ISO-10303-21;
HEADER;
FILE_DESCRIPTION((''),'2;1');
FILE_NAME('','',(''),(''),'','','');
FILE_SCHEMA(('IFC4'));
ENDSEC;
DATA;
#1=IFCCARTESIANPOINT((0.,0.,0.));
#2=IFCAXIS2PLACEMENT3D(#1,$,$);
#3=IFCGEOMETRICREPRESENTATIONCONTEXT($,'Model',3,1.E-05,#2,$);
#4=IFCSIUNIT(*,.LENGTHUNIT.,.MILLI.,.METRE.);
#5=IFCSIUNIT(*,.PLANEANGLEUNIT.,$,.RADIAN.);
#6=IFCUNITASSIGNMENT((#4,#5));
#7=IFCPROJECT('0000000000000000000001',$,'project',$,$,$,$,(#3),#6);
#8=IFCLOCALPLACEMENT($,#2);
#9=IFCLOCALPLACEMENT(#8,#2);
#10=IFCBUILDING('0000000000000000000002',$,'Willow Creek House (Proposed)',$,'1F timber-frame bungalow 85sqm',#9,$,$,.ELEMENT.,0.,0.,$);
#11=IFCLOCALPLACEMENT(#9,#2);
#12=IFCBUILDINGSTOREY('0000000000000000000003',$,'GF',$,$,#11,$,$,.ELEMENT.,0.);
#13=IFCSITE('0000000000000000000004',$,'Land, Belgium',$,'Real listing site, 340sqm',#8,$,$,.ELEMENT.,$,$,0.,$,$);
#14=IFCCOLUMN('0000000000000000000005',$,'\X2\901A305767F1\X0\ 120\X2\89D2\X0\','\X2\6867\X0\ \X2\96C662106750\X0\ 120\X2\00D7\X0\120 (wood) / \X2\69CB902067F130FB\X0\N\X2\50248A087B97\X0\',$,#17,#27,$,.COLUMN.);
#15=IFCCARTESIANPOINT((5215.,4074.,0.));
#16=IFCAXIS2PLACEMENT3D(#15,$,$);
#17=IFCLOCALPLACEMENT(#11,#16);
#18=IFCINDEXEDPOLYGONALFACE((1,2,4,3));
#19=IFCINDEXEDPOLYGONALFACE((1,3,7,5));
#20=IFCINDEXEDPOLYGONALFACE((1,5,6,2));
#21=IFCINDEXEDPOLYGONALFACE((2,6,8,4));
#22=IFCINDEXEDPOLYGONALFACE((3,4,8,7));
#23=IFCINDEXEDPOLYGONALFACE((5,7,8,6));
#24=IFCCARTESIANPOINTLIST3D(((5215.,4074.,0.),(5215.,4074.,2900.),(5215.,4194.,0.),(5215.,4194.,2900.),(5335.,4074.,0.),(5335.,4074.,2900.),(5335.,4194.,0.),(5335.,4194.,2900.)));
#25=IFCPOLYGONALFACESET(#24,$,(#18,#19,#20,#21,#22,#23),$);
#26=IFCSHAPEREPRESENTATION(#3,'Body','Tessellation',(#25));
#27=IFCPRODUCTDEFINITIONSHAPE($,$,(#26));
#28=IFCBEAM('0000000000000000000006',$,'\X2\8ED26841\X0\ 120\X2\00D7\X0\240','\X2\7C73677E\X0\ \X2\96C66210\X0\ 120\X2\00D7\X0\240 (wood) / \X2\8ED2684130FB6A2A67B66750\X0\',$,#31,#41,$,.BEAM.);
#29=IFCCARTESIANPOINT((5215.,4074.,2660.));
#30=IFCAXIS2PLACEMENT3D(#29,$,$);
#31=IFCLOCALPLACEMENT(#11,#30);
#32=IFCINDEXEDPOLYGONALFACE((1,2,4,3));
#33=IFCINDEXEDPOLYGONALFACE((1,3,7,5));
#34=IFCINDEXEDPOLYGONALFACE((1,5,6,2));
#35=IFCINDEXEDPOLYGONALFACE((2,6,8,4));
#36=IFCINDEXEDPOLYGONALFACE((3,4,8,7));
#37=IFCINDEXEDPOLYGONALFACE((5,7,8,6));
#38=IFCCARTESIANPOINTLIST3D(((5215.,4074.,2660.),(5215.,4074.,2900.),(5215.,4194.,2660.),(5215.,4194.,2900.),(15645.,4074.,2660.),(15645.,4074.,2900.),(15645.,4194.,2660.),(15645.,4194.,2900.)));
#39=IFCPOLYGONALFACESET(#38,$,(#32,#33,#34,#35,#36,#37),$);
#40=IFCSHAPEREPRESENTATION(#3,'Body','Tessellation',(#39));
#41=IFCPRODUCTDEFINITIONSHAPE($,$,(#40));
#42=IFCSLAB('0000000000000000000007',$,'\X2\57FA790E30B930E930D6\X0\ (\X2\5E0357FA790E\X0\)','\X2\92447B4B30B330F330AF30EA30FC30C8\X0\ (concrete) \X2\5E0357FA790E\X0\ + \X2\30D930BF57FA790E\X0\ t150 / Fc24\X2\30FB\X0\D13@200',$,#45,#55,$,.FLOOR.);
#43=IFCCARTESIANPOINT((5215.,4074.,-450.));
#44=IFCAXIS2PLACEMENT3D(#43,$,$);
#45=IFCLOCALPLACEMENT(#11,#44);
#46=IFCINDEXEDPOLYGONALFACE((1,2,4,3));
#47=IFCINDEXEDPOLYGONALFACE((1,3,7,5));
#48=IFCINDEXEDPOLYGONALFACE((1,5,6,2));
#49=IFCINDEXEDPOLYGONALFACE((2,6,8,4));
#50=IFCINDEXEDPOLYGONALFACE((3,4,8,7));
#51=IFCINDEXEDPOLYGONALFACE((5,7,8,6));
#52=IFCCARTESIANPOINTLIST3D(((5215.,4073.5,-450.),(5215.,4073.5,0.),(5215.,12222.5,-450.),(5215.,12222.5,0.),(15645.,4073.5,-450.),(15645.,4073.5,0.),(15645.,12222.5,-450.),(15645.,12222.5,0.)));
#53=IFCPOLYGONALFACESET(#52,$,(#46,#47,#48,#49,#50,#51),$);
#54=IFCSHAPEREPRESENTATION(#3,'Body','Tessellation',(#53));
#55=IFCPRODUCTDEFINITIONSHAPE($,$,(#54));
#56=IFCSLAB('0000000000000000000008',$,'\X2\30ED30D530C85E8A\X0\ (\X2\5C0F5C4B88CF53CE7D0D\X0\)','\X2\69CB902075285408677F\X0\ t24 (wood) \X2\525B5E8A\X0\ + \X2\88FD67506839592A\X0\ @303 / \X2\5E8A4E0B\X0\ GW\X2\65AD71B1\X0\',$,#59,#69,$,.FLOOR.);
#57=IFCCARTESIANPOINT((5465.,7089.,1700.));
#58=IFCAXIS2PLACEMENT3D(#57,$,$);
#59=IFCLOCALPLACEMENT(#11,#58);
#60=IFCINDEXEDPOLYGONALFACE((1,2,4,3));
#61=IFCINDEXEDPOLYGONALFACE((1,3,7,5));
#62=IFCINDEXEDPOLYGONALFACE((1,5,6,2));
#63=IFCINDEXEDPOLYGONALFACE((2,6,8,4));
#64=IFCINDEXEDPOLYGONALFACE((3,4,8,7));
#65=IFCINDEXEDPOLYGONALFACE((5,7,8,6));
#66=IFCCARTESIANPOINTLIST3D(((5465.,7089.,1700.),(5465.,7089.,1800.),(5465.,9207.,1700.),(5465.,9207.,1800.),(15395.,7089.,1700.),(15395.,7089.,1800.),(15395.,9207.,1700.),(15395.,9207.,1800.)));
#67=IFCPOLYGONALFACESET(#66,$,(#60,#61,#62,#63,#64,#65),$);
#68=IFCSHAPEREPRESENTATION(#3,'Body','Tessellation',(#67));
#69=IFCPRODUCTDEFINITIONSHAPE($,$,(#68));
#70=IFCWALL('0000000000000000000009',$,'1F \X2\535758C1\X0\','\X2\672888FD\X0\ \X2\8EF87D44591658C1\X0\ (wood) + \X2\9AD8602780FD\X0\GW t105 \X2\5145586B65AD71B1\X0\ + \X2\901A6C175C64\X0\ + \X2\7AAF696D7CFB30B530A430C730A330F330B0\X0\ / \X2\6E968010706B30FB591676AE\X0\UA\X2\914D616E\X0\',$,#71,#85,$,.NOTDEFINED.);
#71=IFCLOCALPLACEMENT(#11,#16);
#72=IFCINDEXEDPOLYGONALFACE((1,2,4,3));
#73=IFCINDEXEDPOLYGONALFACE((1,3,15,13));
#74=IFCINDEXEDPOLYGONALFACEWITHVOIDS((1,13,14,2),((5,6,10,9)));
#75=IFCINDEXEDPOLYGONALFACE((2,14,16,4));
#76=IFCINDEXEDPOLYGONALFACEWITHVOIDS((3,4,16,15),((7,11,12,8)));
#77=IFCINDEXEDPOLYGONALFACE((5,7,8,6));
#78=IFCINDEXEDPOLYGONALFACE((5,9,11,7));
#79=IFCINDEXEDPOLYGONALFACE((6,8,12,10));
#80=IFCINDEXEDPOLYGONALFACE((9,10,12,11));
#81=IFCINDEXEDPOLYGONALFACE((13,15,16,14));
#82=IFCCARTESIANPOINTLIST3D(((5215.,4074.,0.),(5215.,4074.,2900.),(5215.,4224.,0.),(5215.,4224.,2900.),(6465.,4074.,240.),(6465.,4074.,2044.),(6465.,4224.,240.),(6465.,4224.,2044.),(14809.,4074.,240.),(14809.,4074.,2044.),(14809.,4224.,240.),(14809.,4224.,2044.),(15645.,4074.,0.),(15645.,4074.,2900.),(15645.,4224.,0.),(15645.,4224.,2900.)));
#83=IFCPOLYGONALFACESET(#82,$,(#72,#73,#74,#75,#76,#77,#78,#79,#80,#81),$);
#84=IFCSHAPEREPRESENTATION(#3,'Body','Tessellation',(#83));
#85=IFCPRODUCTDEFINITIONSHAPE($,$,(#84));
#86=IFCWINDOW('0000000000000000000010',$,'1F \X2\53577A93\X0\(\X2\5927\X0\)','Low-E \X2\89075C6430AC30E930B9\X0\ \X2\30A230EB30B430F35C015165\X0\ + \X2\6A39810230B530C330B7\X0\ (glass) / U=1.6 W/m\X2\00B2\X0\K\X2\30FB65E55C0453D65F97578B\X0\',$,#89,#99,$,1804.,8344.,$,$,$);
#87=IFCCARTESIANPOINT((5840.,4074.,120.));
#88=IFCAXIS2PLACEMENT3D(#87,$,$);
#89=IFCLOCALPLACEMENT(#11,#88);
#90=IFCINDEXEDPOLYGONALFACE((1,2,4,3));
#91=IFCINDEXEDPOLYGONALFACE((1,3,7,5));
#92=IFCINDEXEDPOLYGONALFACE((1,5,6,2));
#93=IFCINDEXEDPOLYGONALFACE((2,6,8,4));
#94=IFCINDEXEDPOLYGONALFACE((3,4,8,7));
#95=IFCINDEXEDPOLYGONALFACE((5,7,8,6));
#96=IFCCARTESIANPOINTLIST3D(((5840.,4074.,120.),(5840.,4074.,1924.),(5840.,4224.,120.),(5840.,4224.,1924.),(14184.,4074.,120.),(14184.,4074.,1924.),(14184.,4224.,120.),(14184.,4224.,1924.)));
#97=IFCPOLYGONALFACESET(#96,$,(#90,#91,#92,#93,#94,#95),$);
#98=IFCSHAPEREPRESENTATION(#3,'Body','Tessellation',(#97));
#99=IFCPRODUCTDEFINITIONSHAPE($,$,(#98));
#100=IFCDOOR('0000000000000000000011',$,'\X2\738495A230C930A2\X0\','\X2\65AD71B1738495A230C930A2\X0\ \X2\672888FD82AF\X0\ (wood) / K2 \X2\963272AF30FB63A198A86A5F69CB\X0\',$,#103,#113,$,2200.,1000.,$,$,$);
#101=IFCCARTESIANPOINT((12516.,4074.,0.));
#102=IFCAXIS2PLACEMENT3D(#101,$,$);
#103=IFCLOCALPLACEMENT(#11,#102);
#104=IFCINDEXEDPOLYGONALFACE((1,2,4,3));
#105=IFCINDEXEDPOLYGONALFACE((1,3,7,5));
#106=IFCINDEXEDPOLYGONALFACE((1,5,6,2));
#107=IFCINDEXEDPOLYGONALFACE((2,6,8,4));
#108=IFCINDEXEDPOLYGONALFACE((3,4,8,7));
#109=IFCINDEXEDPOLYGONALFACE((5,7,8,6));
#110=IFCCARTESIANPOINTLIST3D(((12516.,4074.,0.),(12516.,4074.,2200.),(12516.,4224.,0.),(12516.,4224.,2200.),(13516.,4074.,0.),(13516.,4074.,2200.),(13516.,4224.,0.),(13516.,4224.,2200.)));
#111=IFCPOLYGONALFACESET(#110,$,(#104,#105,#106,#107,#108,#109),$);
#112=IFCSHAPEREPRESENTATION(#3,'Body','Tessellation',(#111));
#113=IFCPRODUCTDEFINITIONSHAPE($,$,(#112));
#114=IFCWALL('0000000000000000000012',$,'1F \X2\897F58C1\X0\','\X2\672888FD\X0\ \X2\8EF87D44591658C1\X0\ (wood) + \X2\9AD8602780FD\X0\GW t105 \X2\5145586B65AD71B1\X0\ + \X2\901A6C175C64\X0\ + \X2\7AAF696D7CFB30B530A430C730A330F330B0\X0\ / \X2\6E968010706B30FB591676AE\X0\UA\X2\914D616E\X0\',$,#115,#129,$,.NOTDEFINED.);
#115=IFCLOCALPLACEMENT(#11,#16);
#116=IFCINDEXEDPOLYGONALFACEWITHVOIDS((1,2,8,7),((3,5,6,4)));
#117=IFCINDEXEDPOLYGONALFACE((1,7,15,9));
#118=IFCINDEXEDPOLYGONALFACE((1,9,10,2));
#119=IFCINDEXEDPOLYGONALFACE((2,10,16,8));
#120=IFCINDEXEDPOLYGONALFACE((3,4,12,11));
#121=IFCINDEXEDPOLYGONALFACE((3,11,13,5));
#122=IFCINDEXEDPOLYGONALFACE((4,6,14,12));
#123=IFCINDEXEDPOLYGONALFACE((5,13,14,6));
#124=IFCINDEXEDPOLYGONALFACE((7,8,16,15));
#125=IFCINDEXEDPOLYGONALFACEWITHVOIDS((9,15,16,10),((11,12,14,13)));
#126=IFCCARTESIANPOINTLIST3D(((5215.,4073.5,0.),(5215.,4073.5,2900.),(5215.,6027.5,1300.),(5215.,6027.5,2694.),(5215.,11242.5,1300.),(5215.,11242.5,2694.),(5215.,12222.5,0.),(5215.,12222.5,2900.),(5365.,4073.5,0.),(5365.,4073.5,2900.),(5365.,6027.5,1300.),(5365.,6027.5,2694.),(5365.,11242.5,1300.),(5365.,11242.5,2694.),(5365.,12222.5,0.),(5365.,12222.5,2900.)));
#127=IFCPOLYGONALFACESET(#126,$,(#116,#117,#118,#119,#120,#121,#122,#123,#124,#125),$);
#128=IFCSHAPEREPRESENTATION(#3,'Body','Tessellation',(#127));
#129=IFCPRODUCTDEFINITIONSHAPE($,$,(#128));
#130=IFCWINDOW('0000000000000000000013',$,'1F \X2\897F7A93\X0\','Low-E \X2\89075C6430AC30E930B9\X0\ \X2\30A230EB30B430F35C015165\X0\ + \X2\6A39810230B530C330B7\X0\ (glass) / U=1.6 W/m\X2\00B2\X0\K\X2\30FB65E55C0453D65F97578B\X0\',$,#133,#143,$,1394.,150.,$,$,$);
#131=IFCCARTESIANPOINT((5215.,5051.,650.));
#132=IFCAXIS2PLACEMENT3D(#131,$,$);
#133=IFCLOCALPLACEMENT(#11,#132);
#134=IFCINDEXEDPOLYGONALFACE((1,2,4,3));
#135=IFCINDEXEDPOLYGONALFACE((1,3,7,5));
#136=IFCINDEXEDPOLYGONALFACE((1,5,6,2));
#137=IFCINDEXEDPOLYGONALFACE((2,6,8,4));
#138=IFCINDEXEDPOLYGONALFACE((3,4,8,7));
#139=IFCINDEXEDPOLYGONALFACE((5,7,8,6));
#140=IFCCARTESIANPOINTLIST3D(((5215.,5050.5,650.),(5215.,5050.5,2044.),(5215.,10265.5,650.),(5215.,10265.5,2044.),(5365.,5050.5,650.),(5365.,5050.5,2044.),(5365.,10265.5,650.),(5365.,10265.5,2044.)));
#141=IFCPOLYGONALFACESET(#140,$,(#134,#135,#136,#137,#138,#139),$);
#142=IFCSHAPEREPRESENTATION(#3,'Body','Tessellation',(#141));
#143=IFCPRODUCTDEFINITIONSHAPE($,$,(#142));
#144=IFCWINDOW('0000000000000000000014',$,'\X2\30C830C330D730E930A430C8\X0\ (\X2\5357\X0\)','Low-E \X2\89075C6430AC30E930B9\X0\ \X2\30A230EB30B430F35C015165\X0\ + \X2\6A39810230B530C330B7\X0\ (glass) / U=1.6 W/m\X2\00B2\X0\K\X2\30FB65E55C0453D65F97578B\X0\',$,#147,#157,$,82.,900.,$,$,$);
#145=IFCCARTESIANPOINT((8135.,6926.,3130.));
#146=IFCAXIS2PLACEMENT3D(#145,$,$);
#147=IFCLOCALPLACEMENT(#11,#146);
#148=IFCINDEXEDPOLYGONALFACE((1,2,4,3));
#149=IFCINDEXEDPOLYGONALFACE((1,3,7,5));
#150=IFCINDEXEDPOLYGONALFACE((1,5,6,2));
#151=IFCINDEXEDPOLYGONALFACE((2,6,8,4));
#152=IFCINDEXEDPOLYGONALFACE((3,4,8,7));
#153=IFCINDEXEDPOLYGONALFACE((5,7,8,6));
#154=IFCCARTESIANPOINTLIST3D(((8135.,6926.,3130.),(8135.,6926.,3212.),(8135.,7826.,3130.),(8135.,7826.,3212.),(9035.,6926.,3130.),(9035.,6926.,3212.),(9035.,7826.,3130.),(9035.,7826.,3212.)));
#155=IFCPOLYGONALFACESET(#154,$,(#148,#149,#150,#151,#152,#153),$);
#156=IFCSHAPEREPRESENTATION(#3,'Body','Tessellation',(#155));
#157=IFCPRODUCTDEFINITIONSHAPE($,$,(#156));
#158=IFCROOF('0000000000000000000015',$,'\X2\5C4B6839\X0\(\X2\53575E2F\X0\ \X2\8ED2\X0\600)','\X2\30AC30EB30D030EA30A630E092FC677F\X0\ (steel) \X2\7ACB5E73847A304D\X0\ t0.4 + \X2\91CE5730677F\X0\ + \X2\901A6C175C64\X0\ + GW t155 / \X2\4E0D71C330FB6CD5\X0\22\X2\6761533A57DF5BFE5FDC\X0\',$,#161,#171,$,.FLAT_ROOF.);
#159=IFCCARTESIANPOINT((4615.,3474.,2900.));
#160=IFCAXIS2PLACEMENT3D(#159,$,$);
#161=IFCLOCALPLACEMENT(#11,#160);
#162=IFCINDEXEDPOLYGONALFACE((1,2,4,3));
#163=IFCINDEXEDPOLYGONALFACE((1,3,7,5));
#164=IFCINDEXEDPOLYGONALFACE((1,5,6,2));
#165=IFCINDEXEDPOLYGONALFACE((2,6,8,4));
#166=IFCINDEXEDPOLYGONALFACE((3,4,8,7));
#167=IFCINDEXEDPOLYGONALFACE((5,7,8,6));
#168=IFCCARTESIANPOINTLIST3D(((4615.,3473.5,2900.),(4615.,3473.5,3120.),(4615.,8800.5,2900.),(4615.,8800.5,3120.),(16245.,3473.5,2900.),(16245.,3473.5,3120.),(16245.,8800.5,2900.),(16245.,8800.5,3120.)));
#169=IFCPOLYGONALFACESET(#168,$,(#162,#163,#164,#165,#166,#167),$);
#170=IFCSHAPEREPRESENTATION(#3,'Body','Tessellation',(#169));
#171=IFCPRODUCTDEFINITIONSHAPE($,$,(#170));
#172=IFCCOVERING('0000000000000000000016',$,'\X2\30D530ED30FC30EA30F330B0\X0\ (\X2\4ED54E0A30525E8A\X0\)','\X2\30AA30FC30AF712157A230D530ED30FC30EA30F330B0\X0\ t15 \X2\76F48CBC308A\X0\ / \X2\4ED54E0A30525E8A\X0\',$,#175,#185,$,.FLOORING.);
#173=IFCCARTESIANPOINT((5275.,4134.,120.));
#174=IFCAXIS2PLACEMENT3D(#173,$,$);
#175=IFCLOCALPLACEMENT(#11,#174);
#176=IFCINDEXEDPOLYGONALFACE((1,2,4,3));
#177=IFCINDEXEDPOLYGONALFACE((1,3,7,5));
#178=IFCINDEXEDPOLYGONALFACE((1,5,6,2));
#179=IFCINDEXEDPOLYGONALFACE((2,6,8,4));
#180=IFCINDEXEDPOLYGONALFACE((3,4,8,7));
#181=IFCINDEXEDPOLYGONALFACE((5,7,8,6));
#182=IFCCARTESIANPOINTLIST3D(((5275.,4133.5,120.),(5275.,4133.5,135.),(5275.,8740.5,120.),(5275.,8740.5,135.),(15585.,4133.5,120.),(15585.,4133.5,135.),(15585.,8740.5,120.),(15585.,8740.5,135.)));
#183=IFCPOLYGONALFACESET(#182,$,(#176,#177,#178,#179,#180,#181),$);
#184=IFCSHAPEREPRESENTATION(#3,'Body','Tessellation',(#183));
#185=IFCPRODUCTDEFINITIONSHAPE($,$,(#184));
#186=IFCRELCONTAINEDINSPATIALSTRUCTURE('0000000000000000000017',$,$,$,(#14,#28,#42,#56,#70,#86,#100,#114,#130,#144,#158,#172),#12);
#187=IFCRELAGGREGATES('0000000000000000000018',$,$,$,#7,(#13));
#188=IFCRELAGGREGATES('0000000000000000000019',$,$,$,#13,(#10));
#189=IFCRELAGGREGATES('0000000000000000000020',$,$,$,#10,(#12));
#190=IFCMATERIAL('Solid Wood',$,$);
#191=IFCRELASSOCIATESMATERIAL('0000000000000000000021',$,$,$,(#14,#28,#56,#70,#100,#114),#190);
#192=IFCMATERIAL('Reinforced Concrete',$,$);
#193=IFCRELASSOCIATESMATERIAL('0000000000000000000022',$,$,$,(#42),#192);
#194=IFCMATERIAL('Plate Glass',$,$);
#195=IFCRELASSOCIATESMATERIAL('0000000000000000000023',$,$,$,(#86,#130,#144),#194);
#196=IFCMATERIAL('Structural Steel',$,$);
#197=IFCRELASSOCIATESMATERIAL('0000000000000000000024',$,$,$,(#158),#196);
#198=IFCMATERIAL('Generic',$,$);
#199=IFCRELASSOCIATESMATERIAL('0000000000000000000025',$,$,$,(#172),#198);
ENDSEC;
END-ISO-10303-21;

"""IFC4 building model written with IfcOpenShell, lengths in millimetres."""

from ifc_helpers import new_model, si_unit, frame, frame_2d, origin, place, context, project, spatial, rectangle, extrude, material, element, fill, save


model = new_model("IFC4")

# Units and contexts
model_context = context("Model", 3, precision=1e-05, world=origin())
ifc_project = project(units=[si_unit("LENGTHUNIT", "METRE", prefix="MILLI"), si_unit("PLANEANGLEUNIT", "RADIAN")], contexts=[model_context])

# Site, building, storey
site_placement = place(None, origin())
site = spatial("IfcSite", under=ifc_project, at=site_placement, Name="Land, Belgium", ObjectType="Real listing site, 340sqm", CompositionType="ELEMENT", RefElevation=0.0)
building_placement = place(site_placement, origin())
building = spatial("IfcBuilding", under=site, at=building_placement, Name="Willow Creek House (Proposed)", ObjectType="1F timber-frame bungalow 85sqm", CompositionType="ELEMENT", ElevationOfRefHeight=0.0, ElevationOfTerrain=0.0)
storey_placement = place(building_placement, origin())
storey = spatial("IfcBuildingStorey", under=building, at=storey_placement, Name="GF", CompositionType="ELEMENT", Elevation=0.0)

# Column
ifc_material_1 = material(Name="Solid Wood")
column_1_placement = place(storey_placement, frame((5215.0, 4074.0, 0.0)))
element("IfcColumn", 1, at=column_1_placement, inside=storey, material=ifc_material_1, Name="通し柱 120角", Description="桧 集成材 120×120 (wood) / 構造柱・N値計算", PredefinedType="COLUMN", context=model_context, shape_type="SweptSolid", body=[
    extrude(rectangle(XDim=120.0, YDim=120.0, at=frame_2d((60.0, 60.0))), frame((5215.0, 4074.0, 0.0)), (0.0, 0.0, 1.0), 2900.0),
])

# Beam
beam_1_placement = place(storey_placement, frame((5215.0, 4074.0, 2660.0)))
element("IfcBeam", 2, at=beam_1_placement, inside=storey, material=ifc_material_1, Name="軒桁 120×240", Description="米松 集成 120×240 (wood) / 軒桁・横架材", PredefinedType="BEAM", context=model_context, shape_type="SweptSolid", body=[
    extrude(rectangle(XDim=10430.0, YDim=120.0, at=frame_2d((5215.0, 60.0))), frame((5215.0, 4074.0, 2660.0)), (0.0, 0.0, 1.0), 240.0),
])

# Slabs
ifc_material_2 = material(Name="Reinforced Concrete")
slab_1_placement = place(storey_placement, frame((5215.0, 4074.0, -450.0)))
element("IfcSlab", 3, at=slab_1_placement, inside=storey, material=ifc_material_2, Name="基礎スラブ (布基礎)", Description="鉄筋コンクリート (concrete) 布基礎 + ベタ基礎 t150 / Fc24・D13@200", PredefinedType="FLOOR", context=model_context, shape_type="SweptSolid", body=[
    extrude(rectangle(XDim=10430.0, YDim=8149.0, at=frame_2d((5215.0, 4074.0))), frame((5215.0, 4074.0, -450.0)), (0.0, 0.0, 1.0), 450.0),
])
slab_2_placement = place(storey_placement, frame((5465.0, 7089.0, 1700.0)))
element("IfcSlab", 4, at=slab_2_placement, inside=storey, material=ifc_material_1, Name="ロフト床 (小屋裏収納)", Description="構造用合板 t24 (wood) 剛床 + 製材根太 @303 / 床下 GW断熱", PredefinedType="FLOOR", context=model_context, shape_type="SweptSolid", body=[
    extrude(rectangle(XDim=9930.0, YDim=2118.0, at=frame_2d((4965.0, 1059.0))), frame((5465.0, 7089.0, 1700.0)), (0.0, 0.0, 1.0), 100.0),
])

# Wall, openings, window, door
wall_1_placement = place(storey_placement, frame((5215.0, 4074.0, 0.0)))
wall_1 = element("IfcWall", 5, at=wall_1_placement, inside=storey, material=ifc_material_1, Name="1F 南壁", Description="木製 軸組外壁 (wood) + 高性能GW t105 充填断熱 + 通気層 + 窯業系サイディング / 準耐火・外皮UA配慮", PredefinedType="NOTDEFINED", context=model_context, shape_type="SweptSolid", body=[
    extrude(rectangle(XDim=10430.0, YDim=150.0, at=frame_2d((5215.0, 75.0))), frame((5215.0, 4074.0, 0.0)), (0.0, 0.0, 1.0), 2900.0),
])
opening_1_placement = place(storey_placement, frame((5840.0, 4074.0, 120.0)))
opening_1 = element("IfcOpeningElement", 6, at=opening_1_placement, cuts=wall_1, PredefinedType="NOTDEFINED", context=model_context, shape_type="SweptSolid", body=[
    extrude(rectangle(XDim=8344.0, YDim=150.0, at=frame_2d((4172.0, 75.0))), frame((5840.0, 4074.0, 120.0)), (0.0, 0.0, 1.0), 1804.0),
])
opening_2_placement = place(storey_placement, frame((12516.0, 4074.0, 0.0)))
opening_2 = element("IfcOpeningElement", 7, at=opening_2_placement, cuts=wall_1, PredefinedType="NOTDEFINED", context=model_context, shape_type="SweptSolid", body=[
    extrude(rectangle(XDim=1000.0, YDim=150.0, at=frame_2d((500.0, 75.0))), frame((12516.0, 4074.0, 0.0)), (0.0, 0.0, 1.0), 2200.0),
])
ifc_material_3 = material(Name="Plate Glass")
window_1_placement = place(storey_placement, frame((5840.0, 4074.0, 120.0)))
window_1 = element("IfcWindow", 8, at=window_1_placement, inside=storey, material=ifc_material_3, Name="1F 南窓(大)", Description="Low-E 複層ガラス アルゴン封入 + 樹脂サッシ (glass) / U=1.6 W/m²K・日射取得型", OverallHeight=1804.0, OverallWidth=8344.0, context=model_context, shape_type="SweptSolid", body=[
    extrude(rectangle(XDim=8344.0, YDim=150.0, at=frame_2d((4172.0, 75.0))), frame((5840.0, 4074.0, 120.0)), (0.0, 0.0, 1.0), 1804.0),
])
fill(opening_1, window_1)
door_placement = place(storey_placement, frame((12516.0, 4074.0, 0.0)))
door = element("IfcDoor", 9, at=door_placement, inside=storey, material=ifc_material_1, Name="玄関ドア", Description="断熱玄関ドア 木製芯 (wood) / K2 防犯・採風機構", OverallHeight=2200.0, OverallWidth=1000.0, context=model_context, shape_type="SweptSolid", body=[
    extrude(rectangle(XDim=1000.0, YDim=150.0, at=frame_2d((500.0, 75.0))), frame((12516.0, 4074.0, 0.0)), (0.0, 0.0, 1.0), 2200.0),
])
fill(opening_2, door)

# Wall, opening, window
wall_2_placement = place(storey_placement, frame((5215.0, 4074.0, 0.0)))
wall_2 = element("IfcWall", 10, at=wall_2_placement, inside=storey, material=ifc_material_1, Name="1F 西壁", Description="木製 軸組外壁 (wood) + 高性能GW t105 充填断熱 + 通気層 + 窯業系サイディング / 準耐火・外皮UA配慮", PredefinedType="NOTDEFINED", context=model_context, shape_type="SweptSolid", body=[
    extrude(rectangle(XDim=150.0, YDim=8149.0, at=frame_2d((75.0, 4074.0))), frame((5215.0, 4074.0, 0.0)), (0.0, 0.0, 1.0), 2900.0),
])
opening_3_placement = place(storey_placement, frame((5215.0, 5051.0, 650.0)))
opening_3 = element("IfcOpeningElement", 11, at=opening_3_placement, cuts=wall_2, PredefinedType="NOTDEFINED", context=model_context, shape_type="SweptSolid", body=[
    extrude(rectangle(XDim=150.0, YDim=5215.0, at=frame_2d((75.0, 2607.0))), frame((5215.0, 5051.0, 650.0)), (0.0, 0.0, 1.0), 1394.0),
])
window_2_placement = place(storey_placement, frame((5215.0, 5051.0, 650.0)))
window_2 = element("IfcWindow", 12, at=window_2_placement, inside=storey, material=ifc_material_3, Name="1F 西窓", Description="Low-E 複層ガラス アルゴン封入 + 樹脂サッシ (glass) / U=1.6 W/m²K・日射取得型", OverallHeight=1394.0, OverallWidth=150.0, context=model_context, shape_type="SweptSolid", body=[
    extrude(rectangle(XDim=150.0, YDim=5215.0, at=frame_2d((75.0, 2607.0))), frame((5215.0, 5051.0, 650.0)), (0.0, 0.0, 1.0), 1394.0),
])
fill(opening_3, window_2)

# Window
window_3_placement = place(storey_placement, frame((8135.0, 6926.0, 3130.0)))
element("IfcWindow", 13, at=window_3_placement, inside=storey, material=ifc_material_3, Name="トップライト (南)", Description="Low-E 複層ガラス アルゴン封入 + 樹脂サッシ (glass) / U=1.6 W/m²K・日射取得型", OverallHeight=82.0, OverallWidth=900.0, context=model_context, shape_type="SweptSolid", body=[
    extrude(rectangle(XDim=900.0, YDim=900.0, at=frame_2d((450.0, 450.0))), frame((8135.0, 6926.0, 3130.0)), (0.0, 0.0, 1.0), 82.0),
])

# Roof
ifc_material_4 = material(Name="Structural Steel")
roof_placement = place(storey_placement, frame((4615.0, 3474.0, 2900.0)))
element("IfcRoof", 14, at=roof_placement, inside=storey, material=ifc_material_4, Name="屋根(南帯 軒600)", Description="ガルバリウム鋼板 (steel) 立平葺き t0.4 + 野地板 + 通気層 + GW t155 / 不燃・法22条区域対応", PredefinedType="FLAT_ROOF", context=model_context, shape_type="SweptSolid", body=[
    extrude(rectangle(XDim=11630.0, YDim=5327.0, at=frame_2d((5815.0, 2663.0))), frame((4615.0, 3474.0, 2900.0)), (0.0, 0.0, 1.0), 220.0),
])

# Covering
ifc_material_5 = material(Name="Generic")
covering_1_placement = place(storey_placement, frame((5275.0, 4134.0, 120.0)))
element("IfcCovering", 15, at=covering_1_placement, inside=storey, material=ifc_material_5, Name="フローリング (仕上げ床)", Description="オーク無垢フローリング t15 直貼り / 仕上げ床", PredefinedType="FLOORING", context=model_context, shape_type="SweptSolid", body=[
    extrude(rectangle(XDim=10310.0, YDim=4607.0, at=frame_2d((5155.0, 2303.0))), frame((5275.0, 4134.0, 120.0)), (0.0, 0.0, 1.0), 15.0),
])

save(model, "model.ifc")
